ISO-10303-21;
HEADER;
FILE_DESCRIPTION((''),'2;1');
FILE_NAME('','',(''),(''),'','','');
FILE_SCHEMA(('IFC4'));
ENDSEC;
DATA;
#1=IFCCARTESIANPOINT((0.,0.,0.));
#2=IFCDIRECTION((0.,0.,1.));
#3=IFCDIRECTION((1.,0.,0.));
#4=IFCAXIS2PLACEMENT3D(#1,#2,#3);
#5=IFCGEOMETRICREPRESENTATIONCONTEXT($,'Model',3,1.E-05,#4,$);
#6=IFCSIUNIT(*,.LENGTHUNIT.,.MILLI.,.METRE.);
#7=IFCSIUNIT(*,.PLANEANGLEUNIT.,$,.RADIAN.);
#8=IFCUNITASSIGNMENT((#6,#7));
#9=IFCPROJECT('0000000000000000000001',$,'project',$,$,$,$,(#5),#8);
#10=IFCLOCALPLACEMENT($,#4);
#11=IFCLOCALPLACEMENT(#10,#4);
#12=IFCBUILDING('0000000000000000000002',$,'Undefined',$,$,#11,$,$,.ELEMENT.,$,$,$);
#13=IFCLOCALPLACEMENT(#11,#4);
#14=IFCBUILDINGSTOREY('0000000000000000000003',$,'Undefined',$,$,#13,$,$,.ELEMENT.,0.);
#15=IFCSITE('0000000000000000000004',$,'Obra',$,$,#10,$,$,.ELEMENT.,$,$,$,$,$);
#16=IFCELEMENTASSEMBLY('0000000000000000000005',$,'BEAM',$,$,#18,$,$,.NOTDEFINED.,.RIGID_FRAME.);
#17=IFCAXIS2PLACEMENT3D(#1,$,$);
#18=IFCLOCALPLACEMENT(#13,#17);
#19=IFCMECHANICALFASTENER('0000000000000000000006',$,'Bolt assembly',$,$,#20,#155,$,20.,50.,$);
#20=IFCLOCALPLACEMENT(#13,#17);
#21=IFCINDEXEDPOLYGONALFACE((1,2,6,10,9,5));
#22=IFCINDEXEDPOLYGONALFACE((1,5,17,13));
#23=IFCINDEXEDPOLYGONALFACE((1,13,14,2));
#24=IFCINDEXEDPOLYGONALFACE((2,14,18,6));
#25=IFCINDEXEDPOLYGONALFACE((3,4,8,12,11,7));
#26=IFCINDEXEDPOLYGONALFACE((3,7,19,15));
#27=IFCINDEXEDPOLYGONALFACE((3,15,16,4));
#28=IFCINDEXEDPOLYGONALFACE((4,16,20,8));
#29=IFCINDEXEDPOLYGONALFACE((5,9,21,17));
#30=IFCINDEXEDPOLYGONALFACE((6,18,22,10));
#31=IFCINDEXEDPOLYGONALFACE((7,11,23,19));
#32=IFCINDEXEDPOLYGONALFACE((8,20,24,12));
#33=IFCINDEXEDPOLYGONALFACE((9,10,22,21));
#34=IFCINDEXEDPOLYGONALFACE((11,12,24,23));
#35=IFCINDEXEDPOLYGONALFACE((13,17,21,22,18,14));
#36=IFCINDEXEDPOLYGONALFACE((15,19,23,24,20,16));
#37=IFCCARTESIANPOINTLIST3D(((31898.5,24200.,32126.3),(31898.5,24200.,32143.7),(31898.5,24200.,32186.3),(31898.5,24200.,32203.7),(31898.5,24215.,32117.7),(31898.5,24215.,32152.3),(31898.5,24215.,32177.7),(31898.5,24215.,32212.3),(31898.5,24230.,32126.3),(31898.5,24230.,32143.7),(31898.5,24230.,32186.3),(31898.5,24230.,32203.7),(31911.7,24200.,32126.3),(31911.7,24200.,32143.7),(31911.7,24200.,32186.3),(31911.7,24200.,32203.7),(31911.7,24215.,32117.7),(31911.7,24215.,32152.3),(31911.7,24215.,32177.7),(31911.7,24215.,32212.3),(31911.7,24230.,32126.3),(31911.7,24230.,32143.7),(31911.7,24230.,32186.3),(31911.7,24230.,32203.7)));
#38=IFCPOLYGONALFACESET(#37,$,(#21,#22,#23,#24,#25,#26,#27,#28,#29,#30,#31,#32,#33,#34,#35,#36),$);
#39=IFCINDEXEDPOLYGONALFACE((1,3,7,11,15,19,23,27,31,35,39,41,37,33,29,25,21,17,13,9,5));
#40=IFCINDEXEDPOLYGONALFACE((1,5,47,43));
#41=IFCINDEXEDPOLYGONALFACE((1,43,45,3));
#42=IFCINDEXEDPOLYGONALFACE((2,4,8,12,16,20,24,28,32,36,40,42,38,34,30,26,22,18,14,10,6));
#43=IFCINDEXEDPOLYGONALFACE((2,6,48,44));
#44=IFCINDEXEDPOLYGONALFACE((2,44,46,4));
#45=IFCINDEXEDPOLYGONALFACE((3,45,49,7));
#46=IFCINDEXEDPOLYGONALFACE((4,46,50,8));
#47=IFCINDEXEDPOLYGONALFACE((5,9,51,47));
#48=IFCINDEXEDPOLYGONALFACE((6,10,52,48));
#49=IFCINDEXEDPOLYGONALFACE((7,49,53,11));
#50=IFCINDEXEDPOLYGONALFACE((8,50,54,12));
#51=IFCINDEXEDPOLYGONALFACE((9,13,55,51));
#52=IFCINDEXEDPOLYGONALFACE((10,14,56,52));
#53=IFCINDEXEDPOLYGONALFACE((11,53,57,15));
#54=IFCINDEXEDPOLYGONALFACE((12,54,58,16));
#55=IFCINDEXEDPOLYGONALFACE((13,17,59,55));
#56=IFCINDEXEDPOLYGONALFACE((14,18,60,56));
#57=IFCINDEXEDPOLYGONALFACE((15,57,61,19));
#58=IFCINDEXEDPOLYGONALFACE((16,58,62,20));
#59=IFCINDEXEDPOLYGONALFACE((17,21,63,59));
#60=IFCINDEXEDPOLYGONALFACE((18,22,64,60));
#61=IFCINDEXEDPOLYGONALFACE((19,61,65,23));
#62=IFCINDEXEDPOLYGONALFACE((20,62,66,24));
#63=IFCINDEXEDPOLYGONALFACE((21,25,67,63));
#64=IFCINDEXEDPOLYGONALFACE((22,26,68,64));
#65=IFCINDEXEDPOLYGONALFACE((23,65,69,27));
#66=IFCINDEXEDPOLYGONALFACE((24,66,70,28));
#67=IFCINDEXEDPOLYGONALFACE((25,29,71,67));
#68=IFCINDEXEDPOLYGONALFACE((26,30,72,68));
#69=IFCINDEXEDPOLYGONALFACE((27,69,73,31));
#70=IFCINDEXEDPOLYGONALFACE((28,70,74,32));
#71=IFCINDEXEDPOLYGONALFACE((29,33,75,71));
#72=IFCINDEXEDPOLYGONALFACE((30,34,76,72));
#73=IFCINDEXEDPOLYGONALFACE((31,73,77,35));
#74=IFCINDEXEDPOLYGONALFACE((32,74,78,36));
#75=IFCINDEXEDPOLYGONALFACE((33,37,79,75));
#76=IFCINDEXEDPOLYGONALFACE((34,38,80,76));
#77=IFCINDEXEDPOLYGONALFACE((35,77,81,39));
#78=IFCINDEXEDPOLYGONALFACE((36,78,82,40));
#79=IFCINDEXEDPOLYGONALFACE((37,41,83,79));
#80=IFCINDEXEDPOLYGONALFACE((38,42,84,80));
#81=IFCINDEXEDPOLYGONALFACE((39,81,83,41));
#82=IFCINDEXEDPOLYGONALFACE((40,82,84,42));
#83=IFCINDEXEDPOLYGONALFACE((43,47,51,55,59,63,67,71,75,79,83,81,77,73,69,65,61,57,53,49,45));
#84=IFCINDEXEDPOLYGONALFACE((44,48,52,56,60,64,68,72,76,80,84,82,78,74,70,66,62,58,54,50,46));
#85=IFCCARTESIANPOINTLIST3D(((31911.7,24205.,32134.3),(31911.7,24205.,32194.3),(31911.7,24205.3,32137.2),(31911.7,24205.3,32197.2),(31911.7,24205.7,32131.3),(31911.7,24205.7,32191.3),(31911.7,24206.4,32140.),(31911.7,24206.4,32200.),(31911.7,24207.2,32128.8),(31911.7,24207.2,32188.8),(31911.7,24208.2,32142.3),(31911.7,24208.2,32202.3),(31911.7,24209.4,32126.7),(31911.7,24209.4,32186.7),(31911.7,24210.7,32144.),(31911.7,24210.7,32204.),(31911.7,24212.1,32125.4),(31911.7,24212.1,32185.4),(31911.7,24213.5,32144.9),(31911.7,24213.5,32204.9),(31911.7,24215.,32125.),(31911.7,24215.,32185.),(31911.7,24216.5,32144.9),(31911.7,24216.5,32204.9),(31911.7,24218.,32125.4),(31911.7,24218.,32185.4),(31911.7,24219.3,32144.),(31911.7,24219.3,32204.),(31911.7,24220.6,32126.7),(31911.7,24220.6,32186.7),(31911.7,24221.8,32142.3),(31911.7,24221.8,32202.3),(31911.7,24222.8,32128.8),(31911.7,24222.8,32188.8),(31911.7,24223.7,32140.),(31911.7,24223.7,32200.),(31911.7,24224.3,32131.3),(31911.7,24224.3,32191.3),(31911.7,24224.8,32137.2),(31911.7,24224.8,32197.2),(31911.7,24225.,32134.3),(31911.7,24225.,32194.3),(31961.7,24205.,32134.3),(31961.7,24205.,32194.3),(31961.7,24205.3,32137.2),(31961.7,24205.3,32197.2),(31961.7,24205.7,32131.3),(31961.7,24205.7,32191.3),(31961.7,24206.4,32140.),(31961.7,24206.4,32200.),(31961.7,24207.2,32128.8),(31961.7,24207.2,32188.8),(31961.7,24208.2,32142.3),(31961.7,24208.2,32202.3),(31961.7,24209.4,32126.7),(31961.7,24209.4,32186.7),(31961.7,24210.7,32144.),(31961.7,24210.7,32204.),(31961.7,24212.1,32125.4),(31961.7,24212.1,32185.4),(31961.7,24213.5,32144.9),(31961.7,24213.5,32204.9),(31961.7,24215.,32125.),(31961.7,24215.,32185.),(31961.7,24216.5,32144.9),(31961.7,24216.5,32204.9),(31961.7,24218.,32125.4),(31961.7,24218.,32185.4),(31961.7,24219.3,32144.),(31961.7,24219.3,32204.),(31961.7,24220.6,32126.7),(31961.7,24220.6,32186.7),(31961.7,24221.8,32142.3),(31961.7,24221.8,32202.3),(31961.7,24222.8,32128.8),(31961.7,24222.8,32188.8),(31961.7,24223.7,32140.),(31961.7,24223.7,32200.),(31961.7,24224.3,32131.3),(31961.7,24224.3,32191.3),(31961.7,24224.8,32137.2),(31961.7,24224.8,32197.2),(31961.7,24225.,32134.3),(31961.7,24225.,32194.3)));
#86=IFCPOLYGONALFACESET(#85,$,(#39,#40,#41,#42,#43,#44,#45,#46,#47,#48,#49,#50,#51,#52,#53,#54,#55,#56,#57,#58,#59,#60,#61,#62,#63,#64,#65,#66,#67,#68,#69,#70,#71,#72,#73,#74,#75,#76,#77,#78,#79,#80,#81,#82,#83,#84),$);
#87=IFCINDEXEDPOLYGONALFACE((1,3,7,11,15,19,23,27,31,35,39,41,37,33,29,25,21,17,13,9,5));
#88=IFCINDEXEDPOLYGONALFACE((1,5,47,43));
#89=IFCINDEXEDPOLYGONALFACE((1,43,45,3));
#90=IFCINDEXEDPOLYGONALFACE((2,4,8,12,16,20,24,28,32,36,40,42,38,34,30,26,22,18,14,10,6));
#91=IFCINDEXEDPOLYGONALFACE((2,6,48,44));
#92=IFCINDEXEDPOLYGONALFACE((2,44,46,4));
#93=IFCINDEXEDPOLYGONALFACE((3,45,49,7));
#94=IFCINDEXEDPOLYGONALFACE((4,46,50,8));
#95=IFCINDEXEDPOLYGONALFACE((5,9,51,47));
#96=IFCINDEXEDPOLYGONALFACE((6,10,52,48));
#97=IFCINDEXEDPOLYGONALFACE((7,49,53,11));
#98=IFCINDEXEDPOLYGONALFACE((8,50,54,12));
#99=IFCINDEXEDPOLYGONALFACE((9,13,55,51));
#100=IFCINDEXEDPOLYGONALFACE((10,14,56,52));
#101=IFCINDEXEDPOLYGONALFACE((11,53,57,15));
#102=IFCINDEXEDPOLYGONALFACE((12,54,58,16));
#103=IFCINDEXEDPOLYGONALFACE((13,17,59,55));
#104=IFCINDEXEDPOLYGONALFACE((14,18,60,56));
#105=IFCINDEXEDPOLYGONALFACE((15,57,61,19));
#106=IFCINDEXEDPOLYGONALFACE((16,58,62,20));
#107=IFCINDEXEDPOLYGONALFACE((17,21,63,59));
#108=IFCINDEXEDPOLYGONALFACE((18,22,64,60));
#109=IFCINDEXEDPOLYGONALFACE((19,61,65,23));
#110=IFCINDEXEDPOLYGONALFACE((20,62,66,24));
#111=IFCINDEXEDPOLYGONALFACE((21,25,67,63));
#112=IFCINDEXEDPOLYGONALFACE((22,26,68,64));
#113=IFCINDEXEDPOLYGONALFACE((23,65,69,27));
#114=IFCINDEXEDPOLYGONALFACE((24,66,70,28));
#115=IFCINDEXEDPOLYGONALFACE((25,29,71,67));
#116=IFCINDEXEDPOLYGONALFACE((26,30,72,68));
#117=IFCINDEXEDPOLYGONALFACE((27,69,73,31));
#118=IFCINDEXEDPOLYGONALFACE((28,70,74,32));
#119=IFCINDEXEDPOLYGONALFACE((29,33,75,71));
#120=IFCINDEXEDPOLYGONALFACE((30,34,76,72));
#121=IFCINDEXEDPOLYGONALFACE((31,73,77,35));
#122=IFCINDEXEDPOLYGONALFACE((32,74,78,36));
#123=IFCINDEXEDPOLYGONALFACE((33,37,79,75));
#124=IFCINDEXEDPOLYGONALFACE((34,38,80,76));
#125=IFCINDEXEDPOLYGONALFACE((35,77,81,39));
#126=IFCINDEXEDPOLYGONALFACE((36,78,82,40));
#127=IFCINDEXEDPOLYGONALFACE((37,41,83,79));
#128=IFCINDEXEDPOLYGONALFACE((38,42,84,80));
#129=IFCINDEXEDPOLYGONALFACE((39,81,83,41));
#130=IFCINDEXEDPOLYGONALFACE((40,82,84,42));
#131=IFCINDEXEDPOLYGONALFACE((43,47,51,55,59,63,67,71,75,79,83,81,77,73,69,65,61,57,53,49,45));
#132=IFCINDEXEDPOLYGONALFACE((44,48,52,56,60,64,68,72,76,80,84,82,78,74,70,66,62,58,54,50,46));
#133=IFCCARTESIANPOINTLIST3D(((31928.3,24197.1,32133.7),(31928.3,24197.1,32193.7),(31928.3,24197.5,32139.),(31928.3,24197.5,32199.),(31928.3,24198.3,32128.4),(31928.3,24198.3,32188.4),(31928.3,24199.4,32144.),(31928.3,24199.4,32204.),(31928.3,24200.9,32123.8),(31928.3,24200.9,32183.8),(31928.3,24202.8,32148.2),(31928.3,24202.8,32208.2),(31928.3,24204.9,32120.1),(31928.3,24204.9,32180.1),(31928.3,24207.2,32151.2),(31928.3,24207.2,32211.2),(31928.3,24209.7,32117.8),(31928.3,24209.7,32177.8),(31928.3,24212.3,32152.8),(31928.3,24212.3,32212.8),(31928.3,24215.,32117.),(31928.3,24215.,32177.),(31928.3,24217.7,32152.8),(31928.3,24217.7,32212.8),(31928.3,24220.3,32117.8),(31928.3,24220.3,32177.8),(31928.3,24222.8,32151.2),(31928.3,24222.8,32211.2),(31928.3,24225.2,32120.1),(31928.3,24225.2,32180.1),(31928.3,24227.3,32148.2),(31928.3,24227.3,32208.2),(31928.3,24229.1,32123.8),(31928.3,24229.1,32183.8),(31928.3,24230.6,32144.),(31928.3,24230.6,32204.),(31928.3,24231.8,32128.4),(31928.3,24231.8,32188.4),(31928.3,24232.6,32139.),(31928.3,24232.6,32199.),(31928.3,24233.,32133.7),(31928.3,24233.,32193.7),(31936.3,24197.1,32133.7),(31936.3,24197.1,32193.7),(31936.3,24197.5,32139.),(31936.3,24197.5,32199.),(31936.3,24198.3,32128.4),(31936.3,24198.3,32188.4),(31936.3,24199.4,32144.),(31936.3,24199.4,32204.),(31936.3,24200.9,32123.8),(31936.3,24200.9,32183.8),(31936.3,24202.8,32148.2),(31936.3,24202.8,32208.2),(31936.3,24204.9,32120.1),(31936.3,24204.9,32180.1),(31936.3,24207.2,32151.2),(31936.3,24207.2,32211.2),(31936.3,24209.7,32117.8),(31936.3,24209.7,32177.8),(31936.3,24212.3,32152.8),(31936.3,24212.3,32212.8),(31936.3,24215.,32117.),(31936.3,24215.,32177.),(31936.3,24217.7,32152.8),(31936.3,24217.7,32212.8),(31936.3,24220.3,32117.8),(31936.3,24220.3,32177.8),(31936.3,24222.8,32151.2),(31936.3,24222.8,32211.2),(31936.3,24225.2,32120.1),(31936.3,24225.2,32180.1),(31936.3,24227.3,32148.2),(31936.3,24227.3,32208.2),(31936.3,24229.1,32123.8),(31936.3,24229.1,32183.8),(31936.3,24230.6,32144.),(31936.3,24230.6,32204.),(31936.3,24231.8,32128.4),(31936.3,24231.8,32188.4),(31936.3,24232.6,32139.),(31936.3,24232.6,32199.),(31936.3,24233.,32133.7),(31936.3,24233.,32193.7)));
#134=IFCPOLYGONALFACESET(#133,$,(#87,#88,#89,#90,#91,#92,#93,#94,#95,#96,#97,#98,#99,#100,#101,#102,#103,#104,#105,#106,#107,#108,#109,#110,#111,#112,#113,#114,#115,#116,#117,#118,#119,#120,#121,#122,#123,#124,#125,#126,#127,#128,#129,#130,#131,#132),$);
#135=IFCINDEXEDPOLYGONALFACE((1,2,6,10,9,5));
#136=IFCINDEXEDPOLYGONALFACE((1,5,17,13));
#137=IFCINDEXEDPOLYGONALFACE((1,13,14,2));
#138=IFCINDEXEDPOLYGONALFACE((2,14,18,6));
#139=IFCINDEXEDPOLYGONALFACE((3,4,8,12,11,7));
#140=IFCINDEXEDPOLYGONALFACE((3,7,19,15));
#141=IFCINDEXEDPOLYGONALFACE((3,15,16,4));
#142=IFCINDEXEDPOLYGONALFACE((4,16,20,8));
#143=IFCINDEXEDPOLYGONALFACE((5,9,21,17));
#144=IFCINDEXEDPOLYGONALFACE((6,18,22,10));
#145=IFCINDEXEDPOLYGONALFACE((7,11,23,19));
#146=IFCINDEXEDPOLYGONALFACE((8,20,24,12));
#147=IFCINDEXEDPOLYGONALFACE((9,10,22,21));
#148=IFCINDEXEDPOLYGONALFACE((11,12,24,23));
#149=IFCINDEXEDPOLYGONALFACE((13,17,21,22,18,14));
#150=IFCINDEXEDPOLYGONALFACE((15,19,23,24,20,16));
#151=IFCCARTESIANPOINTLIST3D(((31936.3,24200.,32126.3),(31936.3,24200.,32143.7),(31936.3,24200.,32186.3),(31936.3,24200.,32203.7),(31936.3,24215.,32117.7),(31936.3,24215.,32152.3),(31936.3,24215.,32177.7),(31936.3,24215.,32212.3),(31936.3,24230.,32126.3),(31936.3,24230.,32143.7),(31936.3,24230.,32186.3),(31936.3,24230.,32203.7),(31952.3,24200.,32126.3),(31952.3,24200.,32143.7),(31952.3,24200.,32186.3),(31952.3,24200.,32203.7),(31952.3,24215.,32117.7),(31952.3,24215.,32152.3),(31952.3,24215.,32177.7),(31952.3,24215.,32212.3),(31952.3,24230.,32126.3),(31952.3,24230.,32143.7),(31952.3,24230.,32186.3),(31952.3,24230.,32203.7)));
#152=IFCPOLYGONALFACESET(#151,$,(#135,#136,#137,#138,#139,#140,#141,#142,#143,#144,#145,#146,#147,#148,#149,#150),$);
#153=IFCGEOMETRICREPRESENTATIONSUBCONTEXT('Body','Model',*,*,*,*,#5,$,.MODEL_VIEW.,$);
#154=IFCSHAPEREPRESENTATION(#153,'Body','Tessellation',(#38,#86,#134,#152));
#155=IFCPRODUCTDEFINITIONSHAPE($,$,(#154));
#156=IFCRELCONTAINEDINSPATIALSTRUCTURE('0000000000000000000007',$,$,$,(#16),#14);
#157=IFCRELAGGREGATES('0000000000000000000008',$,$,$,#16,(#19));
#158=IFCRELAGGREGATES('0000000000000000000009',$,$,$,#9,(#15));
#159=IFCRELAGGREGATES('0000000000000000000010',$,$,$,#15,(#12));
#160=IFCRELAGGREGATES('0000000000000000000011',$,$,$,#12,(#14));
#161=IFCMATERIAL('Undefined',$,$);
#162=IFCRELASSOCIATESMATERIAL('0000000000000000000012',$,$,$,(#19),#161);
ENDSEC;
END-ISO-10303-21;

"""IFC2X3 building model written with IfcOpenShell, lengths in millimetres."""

from ifc_helpers import new_model, si_unit, frame, origin_with_axes, origin_2d_with_axis, place, context, subcontext, project, spatial, polyline, circle, outline, extrude, source, transform, mapped, material, element, aggregate, save


model = new_model("IFC2X3")

# Units and contexts
model_context = context("Model", 3, precision=1e-05, world=origin_with_axes())
body_context = subcontext(model_context, "Body", "Model", "MODEL_VIEW")
ifc_project = project(units=[si_unit("LENGTHUNIT", "METRE", prefix="MILLI"), si_unit("PLANEANGLEUNIT", "RADIAN")], contexts=[model_context])

# Site, building, storey
site_placement = place(None, origin_with_axes())
site = spatial("IfcSite", under=ifc_project, at=site_placement, Name="Obra", CompositionType="ELEMENT")
building_placement = place(site_placement, origin_with_axes())
building = spatial("IfcBuilding", under=site, at=building_placement, Name="Undefined", CompositionType="ELEMENT")
storey_placement = place(building_placement, origin_with_axes())
storey = spatial("IfcBuildingStorey", under=building, at=storey_placement, Name="Undefined", CompositionType="ELEMENT", Elevation=0.0)

# Element assembly
assembly_1_placement = place(storey_placement, origin_with_axes())
assembly_1 = element("IfcElementAssembly", 1, at=assembly_1_placement, inside=storey, Name="BEAM", AssemblyPlace="NOTDEFINED", PredefinedType="RIGID_FRAME")

# Shared definitions
ifc_material_1 = material(Name="Undefined")

# Mechanical fastener
shared_shape_1 = source(origin_with_axes(), body_context, "Body", "SweptSolid", [
    extrude(outline(polyline([(17.3, 0.0), (8.7, 15.0), (-8.7, 15.0), (-17.3, 0.0), (-8.7, -15.0), (8.7, -15.0), (17.3, 0.0)])), frame((0.0, -26.5, 0.0), z_axis=(0.0, 1.0, 0.0), x_axis=(1.0, 0.0, 0.0)), (0.0, 0.0, 1.0), 13.2),
    extrude(circle(Radius=10.0, at=origin_2d_with_axis()), frame((0.0, -13.3, 0.0), z_axis=(0.0, 1.0, 0.0), x_axis=(1.0, 0.0, 0.0)), (0.0, 0.0, 1.0), 50.0),
    extrude(circle(Radius=18.0, at=origin_2d_with_axis()), frame((0.0, 3.3, 0.0), z_axis=(0.0, 1.0, 0.0), x_axis=(1.0, 0.0, 0.0)), (0.0, 0.0, 1.0), 8.0),
    extrude(outline(polyline([(17.3, 0.0), (8.7, 15.0), (-8.7, 15.0), (-17.3, 0.0), (-8.7, -15.0), (8.7, -15.0), (17.3, 0.0)])), frame((0.0, 11.3, 0.0), z_axis=(0.0, 1.0, 0.0), x_axis=(1.0, 0.0, 0.0)), (0.0, 0.0, 1.0), 16.0),
])
mechanical_fastener_1_placement = place(assembly_1_placement, frame((31925.0, 24255.0, 32235.0), z_axis=(0.000001, -1.0, 0.0), x_axis=(0.0, 0.0, -1.0)))
mechanical_fastener_1 = element("IfcMechanicalFastener", 2, at=mechanical_fastener_1_placement, material=ifc_material_1, Name="Bolt assembly", NominalDiameter=20.0, NominalLength=50.0, context=body_context, shape_type="MappedRepresentation", body=[
    mapped(shared_shape_1, transform((40.0, 0.0, 40.0))),
    mapped(shared_shape_1, transform((100.0, 0.0, 40.0))),
])
aggregate(assembly_1, [mechanical_fastener_1])

save(model, "model.ifc")
